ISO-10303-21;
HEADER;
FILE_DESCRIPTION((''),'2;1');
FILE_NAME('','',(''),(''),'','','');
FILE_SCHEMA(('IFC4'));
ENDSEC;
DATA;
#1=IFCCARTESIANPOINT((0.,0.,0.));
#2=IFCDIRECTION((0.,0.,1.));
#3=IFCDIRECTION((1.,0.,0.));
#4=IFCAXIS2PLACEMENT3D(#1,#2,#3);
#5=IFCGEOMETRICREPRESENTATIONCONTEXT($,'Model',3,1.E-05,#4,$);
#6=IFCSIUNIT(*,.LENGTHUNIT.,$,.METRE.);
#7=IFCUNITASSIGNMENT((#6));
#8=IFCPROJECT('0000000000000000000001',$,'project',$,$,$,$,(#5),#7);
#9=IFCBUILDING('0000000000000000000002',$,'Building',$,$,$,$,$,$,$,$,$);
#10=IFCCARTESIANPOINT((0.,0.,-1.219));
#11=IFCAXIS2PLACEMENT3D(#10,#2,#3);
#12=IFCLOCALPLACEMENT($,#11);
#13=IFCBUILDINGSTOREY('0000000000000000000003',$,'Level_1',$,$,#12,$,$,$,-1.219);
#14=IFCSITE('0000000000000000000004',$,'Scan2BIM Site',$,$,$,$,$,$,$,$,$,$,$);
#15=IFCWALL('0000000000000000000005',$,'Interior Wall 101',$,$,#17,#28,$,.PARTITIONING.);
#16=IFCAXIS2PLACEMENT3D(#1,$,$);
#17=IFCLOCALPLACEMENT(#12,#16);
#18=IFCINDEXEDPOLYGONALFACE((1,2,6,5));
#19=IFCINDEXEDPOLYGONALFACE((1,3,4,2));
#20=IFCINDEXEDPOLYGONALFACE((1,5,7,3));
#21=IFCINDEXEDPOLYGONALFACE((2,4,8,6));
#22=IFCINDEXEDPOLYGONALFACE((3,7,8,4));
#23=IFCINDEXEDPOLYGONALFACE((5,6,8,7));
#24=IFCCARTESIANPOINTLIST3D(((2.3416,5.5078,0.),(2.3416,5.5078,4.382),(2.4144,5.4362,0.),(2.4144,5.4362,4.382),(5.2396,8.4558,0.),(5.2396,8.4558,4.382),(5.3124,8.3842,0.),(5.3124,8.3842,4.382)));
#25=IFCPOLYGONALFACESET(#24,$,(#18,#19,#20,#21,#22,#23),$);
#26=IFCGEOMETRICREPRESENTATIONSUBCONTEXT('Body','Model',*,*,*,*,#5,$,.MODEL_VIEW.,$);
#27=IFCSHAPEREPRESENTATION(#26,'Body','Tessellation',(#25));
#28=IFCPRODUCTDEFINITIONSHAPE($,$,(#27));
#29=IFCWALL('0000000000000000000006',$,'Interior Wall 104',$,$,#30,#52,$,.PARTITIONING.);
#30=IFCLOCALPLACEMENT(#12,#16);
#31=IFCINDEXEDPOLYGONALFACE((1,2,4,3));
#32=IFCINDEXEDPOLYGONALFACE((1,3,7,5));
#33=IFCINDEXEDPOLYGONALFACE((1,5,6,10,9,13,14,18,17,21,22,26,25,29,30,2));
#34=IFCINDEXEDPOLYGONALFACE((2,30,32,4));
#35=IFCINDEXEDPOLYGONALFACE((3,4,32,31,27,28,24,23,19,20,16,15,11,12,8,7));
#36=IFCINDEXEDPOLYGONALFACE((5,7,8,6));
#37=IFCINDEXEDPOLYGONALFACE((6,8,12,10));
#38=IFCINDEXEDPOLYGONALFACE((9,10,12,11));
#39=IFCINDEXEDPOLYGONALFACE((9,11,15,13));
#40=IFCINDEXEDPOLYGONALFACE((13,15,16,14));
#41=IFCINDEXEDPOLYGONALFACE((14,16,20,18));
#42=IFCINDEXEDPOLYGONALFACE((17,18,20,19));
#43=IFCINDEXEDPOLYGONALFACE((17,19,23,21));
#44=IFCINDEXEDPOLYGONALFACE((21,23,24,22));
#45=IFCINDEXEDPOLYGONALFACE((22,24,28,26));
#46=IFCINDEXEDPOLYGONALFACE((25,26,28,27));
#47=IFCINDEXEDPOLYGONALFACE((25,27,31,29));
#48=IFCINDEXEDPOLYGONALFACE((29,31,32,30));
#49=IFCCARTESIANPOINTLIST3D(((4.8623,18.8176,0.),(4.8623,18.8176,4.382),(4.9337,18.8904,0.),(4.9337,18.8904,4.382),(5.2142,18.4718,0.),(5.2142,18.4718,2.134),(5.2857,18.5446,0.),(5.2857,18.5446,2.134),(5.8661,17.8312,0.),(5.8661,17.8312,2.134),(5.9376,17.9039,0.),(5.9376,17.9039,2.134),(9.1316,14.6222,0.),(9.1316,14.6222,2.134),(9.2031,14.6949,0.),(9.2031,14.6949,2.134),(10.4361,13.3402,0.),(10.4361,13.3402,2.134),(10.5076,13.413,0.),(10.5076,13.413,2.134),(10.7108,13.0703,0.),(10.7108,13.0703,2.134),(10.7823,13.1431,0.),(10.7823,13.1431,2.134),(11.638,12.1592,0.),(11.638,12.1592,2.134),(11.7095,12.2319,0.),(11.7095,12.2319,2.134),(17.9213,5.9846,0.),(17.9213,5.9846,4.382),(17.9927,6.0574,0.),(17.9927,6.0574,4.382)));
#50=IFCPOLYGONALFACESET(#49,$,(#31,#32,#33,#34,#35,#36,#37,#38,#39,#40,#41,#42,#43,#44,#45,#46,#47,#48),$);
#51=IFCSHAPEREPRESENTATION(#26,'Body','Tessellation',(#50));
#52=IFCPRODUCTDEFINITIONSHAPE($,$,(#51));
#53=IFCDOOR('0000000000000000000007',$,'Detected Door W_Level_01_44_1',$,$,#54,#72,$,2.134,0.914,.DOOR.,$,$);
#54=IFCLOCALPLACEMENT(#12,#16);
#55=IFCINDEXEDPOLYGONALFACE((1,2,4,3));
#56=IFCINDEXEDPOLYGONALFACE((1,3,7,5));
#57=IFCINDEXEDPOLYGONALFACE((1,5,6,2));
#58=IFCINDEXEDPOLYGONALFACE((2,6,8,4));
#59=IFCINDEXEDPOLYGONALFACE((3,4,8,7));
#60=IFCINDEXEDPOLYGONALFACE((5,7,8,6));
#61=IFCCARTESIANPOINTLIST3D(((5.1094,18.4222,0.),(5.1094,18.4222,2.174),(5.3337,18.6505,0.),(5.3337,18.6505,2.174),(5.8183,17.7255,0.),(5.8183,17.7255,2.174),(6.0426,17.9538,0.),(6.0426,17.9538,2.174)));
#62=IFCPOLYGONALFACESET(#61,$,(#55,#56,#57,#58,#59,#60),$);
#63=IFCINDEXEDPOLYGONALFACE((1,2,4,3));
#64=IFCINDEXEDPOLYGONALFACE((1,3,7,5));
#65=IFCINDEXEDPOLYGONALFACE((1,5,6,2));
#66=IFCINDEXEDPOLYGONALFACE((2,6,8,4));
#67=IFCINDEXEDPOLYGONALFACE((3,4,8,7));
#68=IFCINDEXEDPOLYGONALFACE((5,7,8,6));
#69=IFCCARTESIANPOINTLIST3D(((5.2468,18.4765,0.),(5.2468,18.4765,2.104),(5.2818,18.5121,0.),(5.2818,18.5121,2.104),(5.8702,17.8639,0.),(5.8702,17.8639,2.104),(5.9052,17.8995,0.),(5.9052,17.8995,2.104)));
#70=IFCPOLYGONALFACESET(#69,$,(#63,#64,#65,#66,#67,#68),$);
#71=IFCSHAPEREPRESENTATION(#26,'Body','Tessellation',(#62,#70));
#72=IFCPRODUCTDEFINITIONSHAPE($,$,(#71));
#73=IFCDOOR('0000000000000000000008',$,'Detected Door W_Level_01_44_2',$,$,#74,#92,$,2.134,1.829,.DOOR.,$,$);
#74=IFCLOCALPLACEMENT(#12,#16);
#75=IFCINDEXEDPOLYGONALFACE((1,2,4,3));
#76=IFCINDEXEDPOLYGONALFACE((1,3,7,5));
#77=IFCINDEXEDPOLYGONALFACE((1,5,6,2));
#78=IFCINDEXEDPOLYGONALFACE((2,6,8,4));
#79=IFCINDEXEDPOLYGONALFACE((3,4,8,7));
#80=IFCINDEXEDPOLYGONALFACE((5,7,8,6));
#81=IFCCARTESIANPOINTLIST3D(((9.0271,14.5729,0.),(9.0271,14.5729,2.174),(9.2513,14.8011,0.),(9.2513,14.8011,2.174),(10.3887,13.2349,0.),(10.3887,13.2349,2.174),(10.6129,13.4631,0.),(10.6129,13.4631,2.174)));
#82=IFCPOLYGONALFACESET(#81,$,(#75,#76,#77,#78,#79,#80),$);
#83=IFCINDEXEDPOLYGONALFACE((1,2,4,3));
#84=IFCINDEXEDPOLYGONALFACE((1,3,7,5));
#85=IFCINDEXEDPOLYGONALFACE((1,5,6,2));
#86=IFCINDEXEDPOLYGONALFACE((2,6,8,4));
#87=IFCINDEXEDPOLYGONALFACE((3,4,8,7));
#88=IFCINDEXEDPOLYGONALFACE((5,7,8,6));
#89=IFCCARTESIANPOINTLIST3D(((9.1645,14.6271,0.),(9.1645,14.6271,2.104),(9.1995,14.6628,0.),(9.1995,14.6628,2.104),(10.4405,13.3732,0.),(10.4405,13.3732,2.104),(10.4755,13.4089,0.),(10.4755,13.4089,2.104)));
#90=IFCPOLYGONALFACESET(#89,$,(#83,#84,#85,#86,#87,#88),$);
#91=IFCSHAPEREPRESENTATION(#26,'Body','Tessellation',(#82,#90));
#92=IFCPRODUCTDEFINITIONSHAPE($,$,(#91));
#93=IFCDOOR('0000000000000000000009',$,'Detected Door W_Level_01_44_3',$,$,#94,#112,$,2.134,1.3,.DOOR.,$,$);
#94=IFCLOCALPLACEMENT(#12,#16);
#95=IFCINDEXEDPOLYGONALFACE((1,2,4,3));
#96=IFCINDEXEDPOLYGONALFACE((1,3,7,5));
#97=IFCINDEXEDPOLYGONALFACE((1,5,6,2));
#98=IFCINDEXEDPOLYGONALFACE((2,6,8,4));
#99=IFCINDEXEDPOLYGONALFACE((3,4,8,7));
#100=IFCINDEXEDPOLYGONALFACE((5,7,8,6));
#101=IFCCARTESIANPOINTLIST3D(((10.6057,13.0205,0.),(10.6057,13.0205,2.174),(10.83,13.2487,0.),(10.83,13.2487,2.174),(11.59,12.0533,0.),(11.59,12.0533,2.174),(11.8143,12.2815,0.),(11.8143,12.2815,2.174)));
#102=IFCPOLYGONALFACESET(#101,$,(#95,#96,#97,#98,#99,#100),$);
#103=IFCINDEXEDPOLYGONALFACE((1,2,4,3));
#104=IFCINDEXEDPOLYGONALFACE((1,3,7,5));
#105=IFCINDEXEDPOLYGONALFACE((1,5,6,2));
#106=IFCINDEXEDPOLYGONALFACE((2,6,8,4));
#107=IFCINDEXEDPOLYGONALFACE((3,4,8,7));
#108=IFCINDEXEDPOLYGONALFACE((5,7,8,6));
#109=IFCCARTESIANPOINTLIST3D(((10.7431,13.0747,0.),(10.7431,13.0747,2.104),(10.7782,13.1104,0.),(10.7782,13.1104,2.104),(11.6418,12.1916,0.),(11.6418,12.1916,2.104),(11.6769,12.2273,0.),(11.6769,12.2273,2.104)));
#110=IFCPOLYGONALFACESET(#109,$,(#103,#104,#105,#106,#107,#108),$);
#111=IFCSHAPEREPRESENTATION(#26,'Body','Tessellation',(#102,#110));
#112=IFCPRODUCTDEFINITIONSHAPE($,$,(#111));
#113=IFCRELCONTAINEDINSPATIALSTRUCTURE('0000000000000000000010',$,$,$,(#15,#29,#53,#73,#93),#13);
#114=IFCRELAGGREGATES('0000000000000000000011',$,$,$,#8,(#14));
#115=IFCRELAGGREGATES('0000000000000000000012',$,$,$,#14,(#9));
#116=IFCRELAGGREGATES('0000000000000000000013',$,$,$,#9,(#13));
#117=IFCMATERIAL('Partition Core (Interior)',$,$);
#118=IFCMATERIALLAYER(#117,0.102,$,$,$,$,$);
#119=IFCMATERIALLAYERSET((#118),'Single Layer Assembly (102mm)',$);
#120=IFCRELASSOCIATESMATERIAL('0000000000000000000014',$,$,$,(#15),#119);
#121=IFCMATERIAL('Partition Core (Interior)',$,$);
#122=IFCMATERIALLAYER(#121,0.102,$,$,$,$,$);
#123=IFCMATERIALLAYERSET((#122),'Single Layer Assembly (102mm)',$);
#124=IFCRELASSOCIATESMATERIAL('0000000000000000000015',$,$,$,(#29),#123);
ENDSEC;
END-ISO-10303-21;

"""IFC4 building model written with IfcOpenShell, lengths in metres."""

from ifc_helpers import new_model, si_unit, frame, origin, origin_with_axes, place, context, subcontext, project, spatial, rectangle, extrude, material, layer, layer_set, element, fill, save


model = new_model("IFC4")

# Units and contexts
model_context = context("Model", 3, precision=1e-05, world=origin_with_axes())
body_context = subcontext(model_context, "Body", "Model", "MODEL_VIEW")
ifc_project = project(units=[si_unit("LENGTHUNIT", "METRE")], contexts=[model_context])

# Site, building, storey
site = spatial("IfcSite", under=ifc_project, Name="Scan2BIM Site")
building = spatial("IfcBuilding", under=site, Name="Building")
storey_placement = place(None, frame((0.0, 0.0, -1.219), z_axis=(0.0, 0.0, 1.0), x_axis=(1.0, 0.0, 0.0)))
storey = spatial("IfcBuildingStorey", under=building, at=storey_placement, Name="Level_1", Elevation=-1.219)

# Wall
ifc_material_1 = material(Name="Partition Core (Interior)")
ifc_layer_1 = layer(ifc_material_1, 0.102)
ifc_layer_set_1 = layer_set([ifc_layer_1], Name="Single Layer Assembly (102mm)")
wall_1_placement = place(storey_placement, frame((3.827, 6.946, 0.0), z_axis=(0.0, 0.0, 1.0), x_axis=(-0.701033, -0.713128, 0.0)))
element("IfcWall", 1, at=wall_1_placement, inside=storey, material=ifc_layer_set_1, Name="Interior Wall 101", PredefinedType="PARTITIONING", context=body_context, shape_type="SweptSolid", body=[
    extrude(rectangle(XDim=4.1339, YDim=0.102), origin(), (0.0, 0.0, 1.0), 4.382),
])

# Wall, openings, doors
ifc_material_2 = material(Name="Partition Core (Interior)")
ifc_layer_2 = layer(ifc_material_2, 0.102)
ifc_layer_set_2 = layer_set([ifc_layer_2], Name="Single Layer Assembly (102mm)")
wall_2_placement = place(storey_placement, frame((11.4275, 12.4375, 0.0), z_axis=(0.0, 0.0, 1.0), x_axis=(0.713252, -0.700908, 0.0)))
wall_2 = element("IfcWall", 2, at=wall_2_placement, inside=storey, material=ifc_layer_set_2, Name="Interior Wall 104", PredefinedType="PARTITIONING", context=body_context, shape_type="SweptSolid", body=[
    extrude(rectangle(XDim=18.3091, YDim=0.102), origin(), (0.0, 0.0, 1.0), 4.382),
])
opening_1_placement = place(None, frame((5.576, 18.188, -1.219), z_axis=(0.0, 0.0, 1.0), x_axis=(0.713252, -0.700908, 0.0)))
opening_1 = element("IfcOpeningElement", 3, at=opening_1_placement, cuts=wall_2, PredefinedType="OPENING", context=body_context, shape_type="SweptSolid", body=[
    extrude(rectangle(XDim=0.914, YDim=0.202), origin(), (0.0, 0.0, 1.0), 2.134),
])
opening_2_placement = place(None, frame((9.82, 14.018, -1.219), z_axis=(0.0, 0.0, 1.0), x_axis=(0.713252, -0.700908, 0.0)))
opening_2 = element("IfcOpeningElement", 4, at=opening_2_placement, cuts=wall_2, PredefinedType="OPENING", context=body_context, shape_type="SweptSolid", body=[
    extrude(rectangle(XDim=1.829, YDim=0.202), origin(), (0.0, 0.0, 1.0), 2.134),
])
opening_3_placement = place(None, frame((11.21, 12.651, -1.219), z_axis=(0.0, 0.0, 1.0), x_axis=(0.713252, -0.700908, 0.0)))
opening_3 = element("IfcOpeningElement", 5, at=opening_3_placement, cuts=wall_2, PredefinedType="OPENING", context=body_context, shape_type="SweptSolid", body=[
    extrude(rectangle(XDim=1.3, YDim=0.202), origin(), (0.0, 0.0, 1.0), 2.134),
])
door_1_placement = place(opening_1_placement, frame((0.0, 0.0, 0.0), z_axis=(0.0, 0.0, 1.0), x_axis=(1.0, 0.0, 0.0)))
door_1 = element("IfcDoor", 6, at=door_1_placement, inside=storey, Name="Detected Door W_Level_01_44_1", OverallHeight=2.134, OverallWidth=0.914, PredefinedType="DOOR", context=body_context, shape_type="SweptSolid", body=[
    extrude(rectangle(XDim=0.994, YDim=0.32), origin(), (0.0, 0.0, 1.0), 2.174),
    extrude(rectangle(XDim=0.874, YDim=0.05), origin(), (0.0, 0.0, 1.0), 2.104),
])
fill(opening_1, door_1)
door_2_placement = place(opening_2_placement, frame((0.0, 0.0, 0.0), z_axis=(0.0, 0.0, 1.0), x_axis=(1.0, 0.0, 0.0)))
door_2 = element("IfcDoor", 7, at=door_2_placement, inside=storey, Name="Detected Door W_Level_01_44_2", OverallHeight=2.134, OverallWidth=1.829, PredefinedType="DOOR", context=body_context, shape_type="SweptSolid", body=[
    extrude(rectangle(XDim=1.909, YDim=0.32), origin(), (0.0, 0.0, 1.0), 2.174),
    extrude(rectangle(XDim=1.789, YDim=0.05), origin(), (0.0, 0.0, 1.0), 2.104),
])
fill(opening_2, door_2)
door_3_placement = place(opening_3_placement, frame((0.0, 0.0, 0.0), z_axis=(0.0, 0.0, 1.0), x_axis=(1.0, 0.0, 0.0)))
door_3 = element("IfcDoor", 8, at=door_3_placement, inside=storey, Name="Detected Door W_Level_01_44_3", OverallHeight=2.134, OverallWidth=1.3, PredefinedType="DOOR", context=body_context, shape_type="SweptSolid", body=[
    extrude(rectangle(XDim=1.38, YDim=0.32), origin(), (0.0, 0.0, 1.0), 2.174),
    extrude(rectangle(XDim=1.26, YDim=0.05), origin(), (0.0, 0.0, 1.0), 2.104),
])
fill(opening_3, door_3)

save(model, "model.ifc")
